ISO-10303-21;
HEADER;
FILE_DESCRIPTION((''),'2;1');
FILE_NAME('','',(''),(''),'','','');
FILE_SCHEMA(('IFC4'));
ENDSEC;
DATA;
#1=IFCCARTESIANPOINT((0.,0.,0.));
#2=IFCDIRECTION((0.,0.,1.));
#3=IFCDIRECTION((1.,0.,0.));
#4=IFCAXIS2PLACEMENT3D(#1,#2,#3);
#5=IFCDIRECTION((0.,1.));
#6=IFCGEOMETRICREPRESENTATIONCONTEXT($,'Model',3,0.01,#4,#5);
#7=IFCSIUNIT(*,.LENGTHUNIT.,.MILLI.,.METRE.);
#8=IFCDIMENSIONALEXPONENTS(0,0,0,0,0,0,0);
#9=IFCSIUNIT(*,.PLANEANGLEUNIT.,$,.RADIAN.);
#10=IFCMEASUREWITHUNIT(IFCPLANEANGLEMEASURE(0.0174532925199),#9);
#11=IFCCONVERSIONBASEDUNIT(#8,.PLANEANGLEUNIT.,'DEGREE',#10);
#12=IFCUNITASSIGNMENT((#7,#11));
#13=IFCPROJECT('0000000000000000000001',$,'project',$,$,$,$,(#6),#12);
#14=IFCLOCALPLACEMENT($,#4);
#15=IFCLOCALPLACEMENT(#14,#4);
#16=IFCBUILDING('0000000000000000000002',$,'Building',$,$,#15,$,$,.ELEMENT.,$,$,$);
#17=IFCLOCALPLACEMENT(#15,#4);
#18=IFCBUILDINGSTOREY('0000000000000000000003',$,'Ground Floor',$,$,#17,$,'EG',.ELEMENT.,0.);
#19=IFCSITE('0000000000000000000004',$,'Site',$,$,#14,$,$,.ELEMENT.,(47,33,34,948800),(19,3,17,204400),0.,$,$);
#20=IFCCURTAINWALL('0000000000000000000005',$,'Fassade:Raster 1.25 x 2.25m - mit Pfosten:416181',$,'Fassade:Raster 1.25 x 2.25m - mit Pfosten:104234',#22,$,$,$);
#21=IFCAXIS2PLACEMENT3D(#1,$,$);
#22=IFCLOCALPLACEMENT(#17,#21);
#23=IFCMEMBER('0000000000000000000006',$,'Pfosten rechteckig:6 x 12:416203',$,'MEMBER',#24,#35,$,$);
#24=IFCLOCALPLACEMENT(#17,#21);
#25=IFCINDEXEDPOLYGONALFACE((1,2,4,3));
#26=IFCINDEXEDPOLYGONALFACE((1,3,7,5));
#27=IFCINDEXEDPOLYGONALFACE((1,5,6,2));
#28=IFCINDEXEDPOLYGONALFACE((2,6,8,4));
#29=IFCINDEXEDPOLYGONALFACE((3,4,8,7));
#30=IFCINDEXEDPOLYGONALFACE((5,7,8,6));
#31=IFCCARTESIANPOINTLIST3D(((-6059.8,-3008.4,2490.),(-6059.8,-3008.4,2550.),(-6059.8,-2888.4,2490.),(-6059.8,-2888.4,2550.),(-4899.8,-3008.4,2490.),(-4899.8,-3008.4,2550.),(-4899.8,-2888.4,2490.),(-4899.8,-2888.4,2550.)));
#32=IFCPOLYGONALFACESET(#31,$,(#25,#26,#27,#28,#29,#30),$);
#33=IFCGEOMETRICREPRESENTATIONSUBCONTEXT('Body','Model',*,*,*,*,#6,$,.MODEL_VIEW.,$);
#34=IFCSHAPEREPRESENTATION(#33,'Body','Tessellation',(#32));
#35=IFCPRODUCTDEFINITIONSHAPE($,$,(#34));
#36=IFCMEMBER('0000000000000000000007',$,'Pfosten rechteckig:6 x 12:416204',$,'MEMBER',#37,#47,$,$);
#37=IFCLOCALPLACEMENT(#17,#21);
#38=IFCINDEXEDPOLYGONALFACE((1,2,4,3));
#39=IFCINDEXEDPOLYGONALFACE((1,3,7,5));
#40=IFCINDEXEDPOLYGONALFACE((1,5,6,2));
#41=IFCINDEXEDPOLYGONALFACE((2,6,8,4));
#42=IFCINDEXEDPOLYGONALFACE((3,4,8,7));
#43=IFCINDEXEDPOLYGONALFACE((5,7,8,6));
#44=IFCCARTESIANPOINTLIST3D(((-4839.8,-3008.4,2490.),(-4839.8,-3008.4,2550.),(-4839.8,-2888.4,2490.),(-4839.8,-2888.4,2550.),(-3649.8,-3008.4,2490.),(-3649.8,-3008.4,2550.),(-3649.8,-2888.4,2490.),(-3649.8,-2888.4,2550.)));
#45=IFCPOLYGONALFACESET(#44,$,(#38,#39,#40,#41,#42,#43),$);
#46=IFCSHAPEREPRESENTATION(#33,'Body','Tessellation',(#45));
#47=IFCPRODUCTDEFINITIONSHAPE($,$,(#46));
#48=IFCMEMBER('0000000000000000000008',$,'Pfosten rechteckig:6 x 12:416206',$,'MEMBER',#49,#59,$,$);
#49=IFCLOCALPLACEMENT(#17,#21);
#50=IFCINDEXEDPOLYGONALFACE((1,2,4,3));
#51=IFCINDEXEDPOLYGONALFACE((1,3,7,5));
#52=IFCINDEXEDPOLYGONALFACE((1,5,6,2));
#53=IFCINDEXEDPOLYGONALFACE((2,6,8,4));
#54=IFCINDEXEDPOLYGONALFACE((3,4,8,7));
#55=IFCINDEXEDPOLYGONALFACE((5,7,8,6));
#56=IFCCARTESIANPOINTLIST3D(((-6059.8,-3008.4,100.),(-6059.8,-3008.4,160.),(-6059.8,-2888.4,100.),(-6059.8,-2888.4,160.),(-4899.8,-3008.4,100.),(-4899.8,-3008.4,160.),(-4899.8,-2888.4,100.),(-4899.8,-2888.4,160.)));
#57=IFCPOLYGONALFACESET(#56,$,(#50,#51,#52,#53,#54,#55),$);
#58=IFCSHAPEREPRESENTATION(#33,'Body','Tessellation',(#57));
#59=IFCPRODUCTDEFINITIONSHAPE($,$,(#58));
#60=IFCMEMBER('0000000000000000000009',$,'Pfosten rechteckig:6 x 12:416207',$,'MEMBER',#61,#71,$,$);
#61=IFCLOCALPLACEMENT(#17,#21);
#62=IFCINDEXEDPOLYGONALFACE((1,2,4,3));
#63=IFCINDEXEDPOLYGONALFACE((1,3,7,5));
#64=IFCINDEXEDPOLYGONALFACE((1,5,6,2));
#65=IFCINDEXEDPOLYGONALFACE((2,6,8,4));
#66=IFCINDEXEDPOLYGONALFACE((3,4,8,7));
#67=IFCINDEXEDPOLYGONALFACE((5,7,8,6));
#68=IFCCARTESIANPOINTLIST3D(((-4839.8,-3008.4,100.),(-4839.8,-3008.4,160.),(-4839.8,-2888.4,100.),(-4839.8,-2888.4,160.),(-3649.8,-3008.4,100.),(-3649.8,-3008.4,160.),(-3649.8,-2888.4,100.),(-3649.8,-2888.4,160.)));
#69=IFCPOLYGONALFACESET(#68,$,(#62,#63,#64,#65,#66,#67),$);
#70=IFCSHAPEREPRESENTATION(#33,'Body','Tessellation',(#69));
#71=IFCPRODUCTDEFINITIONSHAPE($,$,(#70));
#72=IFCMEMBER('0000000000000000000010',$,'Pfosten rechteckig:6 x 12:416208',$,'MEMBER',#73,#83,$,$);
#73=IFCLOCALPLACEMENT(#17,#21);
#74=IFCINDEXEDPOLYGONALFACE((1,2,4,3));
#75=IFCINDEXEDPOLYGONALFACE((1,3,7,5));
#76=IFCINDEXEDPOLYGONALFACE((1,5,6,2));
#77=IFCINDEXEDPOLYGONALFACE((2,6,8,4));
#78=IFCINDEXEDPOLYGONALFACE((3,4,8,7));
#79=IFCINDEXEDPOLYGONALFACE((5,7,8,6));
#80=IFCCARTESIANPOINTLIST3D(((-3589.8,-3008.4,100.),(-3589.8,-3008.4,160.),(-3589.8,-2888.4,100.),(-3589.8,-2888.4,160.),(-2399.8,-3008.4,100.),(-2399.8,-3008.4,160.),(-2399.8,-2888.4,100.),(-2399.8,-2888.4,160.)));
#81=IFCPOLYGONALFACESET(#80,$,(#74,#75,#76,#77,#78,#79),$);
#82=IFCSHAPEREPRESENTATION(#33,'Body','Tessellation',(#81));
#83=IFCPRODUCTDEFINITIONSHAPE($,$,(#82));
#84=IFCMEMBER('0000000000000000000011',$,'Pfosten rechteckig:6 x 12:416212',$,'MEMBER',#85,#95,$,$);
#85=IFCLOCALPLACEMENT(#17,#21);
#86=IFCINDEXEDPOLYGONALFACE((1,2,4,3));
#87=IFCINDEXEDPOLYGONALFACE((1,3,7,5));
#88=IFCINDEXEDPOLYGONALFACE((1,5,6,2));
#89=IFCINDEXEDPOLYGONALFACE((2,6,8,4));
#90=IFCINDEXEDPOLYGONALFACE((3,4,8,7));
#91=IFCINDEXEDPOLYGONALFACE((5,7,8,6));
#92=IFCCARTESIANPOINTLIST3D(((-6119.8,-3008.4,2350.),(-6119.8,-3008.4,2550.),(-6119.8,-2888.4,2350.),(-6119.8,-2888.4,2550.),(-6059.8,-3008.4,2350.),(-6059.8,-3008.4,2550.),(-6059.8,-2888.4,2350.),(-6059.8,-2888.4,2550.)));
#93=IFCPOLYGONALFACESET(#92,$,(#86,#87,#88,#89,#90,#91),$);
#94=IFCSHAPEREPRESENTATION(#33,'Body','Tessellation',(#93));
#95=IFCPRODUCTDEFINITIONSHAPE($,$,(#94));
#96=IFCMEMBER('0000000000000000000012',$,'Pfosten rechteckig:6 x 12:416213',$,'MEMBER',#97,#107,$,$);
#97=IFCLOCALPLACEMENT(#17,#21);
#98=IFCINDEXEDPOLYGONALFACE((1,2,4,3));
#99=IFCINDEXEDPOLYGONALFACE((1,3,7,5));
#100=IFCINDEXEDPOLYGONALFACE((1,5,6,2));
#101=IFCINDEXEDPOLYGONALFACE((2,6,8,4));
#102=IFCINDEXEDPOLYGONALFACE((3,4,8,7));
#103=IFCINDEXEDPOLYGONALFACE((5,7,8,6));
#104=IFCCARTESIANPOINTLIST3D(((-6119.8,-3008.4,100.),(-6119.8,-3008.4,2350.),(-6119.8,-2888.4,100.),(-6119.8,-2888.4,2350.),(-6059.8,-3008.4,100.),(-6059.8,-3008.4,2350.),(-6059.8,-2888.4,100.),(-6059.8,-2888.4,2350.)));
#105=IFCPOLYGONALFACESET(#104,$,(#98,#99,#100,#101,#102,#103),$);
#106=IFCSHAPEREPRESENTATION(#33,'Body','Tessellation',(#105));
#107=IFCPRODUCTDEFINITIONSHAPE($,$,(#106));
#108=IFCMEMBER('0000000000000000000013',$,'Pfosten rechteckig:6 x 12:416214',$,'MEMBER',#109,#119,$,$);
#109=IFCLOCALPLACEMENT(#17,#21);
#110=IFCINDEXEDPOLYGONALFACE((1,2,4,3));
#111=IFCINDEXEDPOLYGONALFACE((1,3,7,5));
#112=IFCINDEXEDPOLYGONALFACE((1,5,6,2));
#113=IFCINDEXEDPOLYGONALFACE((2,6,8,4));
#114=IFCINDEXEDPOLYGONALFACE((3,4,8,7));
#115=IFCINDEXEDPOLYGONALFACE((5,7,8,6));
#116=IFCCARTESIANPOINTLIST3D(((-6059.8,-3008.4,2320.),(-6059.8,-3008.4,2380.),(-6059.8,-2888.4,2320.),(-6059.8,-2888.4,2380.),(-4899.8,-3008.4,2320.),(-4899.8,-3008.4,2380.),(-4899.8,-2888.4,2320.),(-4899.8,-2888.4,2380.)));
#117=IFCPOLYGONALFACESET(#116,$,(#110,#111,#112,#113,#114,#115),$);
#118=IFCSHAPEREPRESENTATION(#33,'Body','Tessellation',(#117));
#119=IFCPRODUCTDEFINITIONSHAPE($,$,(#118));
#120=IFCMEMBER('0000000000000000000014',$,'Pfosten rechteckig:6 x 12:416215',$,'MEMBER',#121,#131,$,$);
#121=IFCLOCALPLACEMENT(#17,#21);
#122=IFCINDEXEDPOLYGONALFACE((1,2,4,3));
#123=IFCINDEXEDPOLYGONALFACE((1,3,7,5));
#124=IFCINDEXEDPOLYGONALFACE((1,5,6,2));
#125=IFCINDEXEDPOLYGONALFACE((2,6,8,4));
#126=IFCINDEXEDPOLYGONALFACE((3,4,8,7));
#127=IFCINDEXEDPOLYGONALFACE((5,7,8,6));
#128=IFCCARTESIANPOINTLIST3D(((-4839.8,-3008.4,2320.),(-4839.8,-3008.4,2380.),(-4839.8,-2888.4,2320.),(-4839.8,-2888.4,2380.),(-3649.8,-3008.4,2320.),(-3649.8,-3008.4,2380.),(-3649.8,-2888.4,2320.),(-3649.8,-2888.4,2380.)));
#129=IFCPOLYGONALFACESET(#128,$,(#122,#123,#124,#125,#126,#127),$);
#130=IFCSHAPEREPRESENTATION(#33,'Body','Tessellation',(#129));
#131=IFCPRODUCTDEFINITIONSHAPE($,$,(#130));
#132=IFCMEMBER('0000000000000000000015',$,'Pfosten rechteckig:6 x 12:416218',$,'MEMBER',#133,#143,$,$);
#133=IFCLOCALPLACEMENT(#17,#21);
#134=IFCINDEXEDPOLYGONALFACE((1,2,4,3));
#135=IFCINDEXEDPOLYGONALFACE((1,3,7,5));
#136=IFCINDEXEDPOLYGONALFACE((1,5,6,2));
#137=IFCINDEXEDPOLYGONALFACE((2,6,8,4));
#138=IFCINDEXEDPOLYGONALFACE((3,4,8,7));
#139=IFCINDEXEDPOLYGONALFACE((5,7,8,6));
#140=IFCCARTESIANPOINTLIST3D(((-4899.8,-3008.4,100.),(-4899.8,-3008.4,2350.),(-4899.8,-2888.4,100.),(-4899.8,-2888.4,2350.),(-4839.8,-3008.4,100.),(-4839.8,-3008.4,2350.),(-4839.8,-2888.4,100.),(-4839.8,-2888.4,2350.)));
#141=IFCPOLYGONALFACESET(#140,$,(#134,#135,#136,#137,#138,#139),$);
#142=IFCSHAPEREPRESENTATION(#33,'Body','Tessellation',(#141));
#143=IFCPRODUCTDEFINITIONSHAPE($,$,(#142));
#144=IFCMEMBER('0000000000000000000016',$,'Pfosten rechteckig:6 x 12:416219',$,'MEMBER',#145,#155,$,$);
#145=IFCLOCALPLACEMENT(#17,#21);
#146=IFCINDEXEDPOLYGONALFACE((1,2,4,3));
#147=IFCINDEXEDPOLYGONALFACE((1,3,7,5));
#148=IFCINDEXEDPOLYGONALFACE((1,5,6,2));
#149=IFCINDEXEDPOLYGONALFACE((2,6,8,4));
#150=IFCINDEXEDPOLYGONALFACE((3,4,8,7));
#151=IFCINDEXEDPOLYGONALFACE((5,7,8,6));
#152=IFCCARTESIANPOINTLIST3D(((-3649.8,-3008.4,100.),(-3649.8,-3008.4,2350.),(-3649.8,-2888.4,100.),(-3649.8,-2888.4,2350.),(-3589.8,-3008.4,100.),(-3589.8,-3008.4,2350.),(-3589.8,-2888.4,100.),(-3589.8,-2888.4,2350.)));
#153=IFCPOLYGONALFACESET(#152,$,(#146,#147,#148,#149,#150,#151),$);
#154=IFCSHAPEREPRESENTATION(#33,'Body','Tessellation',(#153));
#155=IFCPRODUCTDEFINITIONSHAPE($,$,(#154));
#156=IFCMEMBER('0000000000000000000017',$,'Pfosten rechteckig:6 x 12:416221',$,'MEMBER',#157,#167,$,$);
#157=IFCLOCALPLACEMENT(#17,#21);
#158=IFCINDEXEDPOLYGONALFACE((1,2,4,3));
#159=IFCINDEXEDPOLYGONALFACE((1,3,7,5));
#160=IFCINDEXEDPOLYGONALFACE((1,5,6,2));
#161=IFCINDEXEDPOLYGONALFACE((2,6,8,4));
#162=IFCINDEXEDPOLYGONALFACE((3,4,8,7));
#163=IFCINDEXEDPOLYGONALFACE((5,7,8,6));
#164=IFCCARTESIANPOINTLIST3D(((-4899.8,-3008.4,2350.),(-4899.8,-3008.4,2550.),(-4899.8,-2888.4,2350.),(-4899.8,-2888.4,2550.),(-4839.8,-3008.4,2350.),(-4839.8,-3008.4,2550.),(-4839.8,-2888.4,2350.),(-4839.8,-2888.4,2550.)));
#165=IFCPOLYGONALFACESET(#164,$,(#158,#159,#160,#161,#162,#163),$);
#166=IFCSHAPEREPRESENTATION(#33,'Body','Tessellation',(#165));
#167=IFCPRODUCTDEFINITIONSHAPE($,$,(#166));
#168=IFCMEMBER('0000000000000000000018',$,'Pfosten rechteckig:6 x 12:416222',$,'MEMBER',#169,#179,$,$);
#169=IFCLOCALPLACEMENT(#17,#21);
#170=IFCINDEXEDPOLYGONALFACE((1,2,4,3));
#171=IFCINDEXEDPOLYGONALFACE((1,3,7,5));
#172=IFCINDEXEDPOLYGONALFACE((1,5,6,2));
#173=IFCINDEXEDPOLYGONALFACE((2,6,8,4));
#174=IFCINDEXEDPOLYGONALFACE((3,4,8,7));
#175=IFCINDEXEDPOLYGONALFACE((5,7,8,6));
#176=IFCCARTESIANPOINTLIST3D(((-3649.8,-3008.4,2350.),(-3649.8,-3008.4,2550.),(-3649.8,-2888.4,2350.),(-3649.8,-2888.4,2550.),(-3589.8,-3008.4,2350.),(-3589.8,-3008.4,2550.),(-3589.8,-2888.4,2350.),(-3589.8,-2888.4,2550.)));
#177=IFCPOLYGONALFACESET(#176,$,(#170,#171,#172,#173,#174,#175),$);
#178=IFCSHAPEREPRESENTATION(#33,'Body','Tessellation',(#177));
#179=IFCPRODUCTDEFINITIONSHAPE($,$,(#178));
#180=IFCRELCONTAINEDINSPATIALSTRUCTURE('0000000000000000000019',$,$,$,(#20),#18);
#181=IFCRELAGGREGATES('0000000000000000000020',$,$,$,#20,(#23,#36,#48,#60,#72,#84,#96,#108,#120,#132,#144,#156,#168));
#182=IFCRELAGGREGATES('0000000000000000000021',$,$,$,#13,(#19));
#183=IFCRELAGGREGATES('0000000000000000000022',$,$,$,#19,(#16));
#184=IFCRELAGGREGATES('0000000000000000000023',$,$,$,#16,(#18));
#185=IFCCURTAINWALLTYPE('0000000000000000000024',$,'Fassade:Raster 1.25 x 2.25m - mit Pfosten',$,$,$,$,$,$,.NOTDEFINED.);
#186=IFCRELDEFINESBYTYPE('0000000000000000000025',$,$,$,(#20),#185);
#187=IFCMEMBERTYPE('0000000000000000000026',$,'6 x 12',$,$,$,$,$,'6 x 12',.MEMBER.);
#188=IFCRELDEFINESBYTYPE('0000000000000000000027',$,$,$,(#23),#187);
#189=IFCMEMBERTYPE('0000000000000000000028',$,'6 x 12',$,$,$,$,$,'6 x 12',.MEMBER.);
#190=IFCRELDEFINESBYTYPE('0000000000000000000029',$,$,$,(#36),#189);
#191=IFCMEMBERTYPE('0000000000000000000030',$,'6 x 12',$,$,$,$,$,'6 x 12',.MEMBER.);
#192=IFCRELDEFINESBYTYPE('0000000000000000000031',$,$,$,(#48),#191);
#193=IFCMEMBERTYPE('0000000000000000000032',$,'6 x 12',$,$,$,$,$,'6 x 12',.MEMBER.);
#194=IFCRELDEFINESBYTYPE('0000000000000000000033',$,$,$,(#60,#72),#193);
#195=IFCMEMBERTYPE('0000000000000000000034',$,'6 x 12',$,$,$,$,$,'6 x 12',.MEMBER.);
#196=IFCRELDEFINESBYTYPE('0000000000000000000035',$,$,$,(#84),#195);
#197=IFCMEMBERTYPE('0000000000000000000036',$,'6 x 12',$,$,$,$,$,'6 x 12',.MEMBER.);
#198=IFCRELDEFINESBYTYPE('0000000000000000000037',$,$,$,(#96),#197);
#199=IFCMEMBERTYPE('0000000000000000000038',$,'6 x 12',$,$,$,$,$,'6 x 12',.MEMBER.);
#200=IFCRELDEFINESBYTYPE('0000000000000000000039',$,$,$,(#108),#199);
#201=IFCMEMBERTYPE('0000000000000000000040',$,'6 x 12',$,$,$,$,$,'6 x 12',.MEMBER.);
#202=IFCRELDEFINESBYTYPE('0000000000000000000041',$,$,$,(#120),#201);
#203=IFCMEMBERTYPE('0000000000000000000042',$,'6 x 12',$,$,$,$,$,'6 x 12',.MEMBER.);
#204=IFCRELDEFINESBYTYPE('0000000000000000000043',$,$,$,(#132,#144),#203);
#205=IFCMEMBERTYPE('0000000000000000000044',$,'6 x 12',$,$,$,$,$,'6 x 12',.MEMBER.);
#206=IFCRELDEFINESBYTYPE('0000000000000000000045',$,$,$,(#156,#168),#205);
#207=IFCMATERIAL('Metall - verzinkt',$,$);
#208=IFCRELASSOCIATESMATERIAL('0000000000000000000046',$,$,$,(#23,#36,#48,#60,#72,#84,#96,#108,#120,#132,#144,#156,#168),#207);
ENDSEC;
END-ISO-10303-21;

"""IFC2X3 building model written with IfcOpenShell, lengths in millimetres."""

from ifc_helpers import new_model, entity, si_unit, converted_unit, direction, frame, origin_with_axes, origin_2d_with_axis, place, context, subcontext, project, spatial, rectangle, extrude, material, type_object, element, aggregate, save


model = new_model("IFC2X3")

# Units and contexts
model_context = context("Model", 3, precision=0.01, world=origin_with_axes(), true_north=direction((0.0, 1.0)))
body_context = subcontext(model_context, "Body", "Model", "MODEL_VIEW")
ifc_project = project(units=[si_unit("LENGTHUNIT", "METRE", prefix="MILLI"), converted_unit("PLANEANGLEUNIT", "DEGREE", entity("IfcPlaneAngleMeasure", 0.0174532925199), si_unit("PLANEANGLEUNIT", "RADIAN"), dimensions=[0, 0, 0, 0, 0, 0, 0])], contexts=[model_context])

# Site, building, storey
site_placement = place(None, origin_with_axes())
site = spatial("IfcSite", under=ifc_project, at=site_placement, Name="Site", CompositionType="ELEMENT", RefLatitude=(47, 33, 34, 948800), RefLongitude=(19, 3, 17, 204400), RefElevation=0.0)
building_placement = place(site_placement, origin_with_axes())
building = spatial("IfcBuilding", under=site, at=building_placement, Name="Building", CompositionType="ELEMENT")
storey_placement = place(building_placement, origin_with_axes())
storey = spatial("IfcBuildingStorey", under=building, at=storey_placement, Name="Ground Floor", LongName="EG", CompositionType="ELEMENT", Elevation=0.0)

# Curtain wall, members
curtain_wall_type = type_object("IfcCurtainWallType", Name="Fassade:Raster 1.25 x 2.25m - mit Pfosten", PredefinedType="NOTDEFINED")
curtain_wall_placement = place(storey_placement, origin_with_axes())
curtain_wall = element("IfcCurtainWall", 1, at=curtain_wall_placement, inside=storey, type_object=curtain_wall_type, Name="Fassade:Raster 1.25 x 2.25m - mit Pfosten:416181", ObjectType="Fassade:Raster 1.25 x 2.25m - mit Pfosten:104234")
ifc_material_1 = material(Name="Metall - verzinkt")
member_type_1 = type_object("IfcMemberType", Name="6 x 12", ElementType="6 x 12", PredefinedType="MEMBER")
member_1_placement = place(curtain_wall_placement, frame((-4899.8, -2948.4, 2550.0), z_axis=(0.0, 0.0, 1.0), x_axis=(0.0, -1.0, 0.0)))
member_1 = element("IfcMember", 2, at=member_1_placement, type_object=member_type_1, material=ifc_material_1, Name="Pfosten rechteckig:6 x 12:416203", ObjectType="MEMBER", context=body_context, shape_type="SweptSolid", body=[
    extrude(rectangle(XDim=120.0, YDim=60.0, at=origin_2d_with_axis()), frame((0.0, -1160.0, -30.0), z_axis=(0.0, 1.0, 0.0), x_axis=(-1.0, 0.0, 0.0)), (0.0, 0.0, 1.0), 1160.0),
])
member_type_2 = type_object("IfcMemberType", Name="6 x 12", ElementType="6 x 12", PredefinedType="MEMBER")
member_2_placement = place(curtain_wall_placement, frame((-3649.8, -2948.4, 2550.0), z_axis=(0.0, 0.0, 1.0), x_axis=(0.0, -1.0, 0.0)))
member_2 = element("IfcMember", 3, at=member_2_placement, type_object=member_type_2, material=ifc_material_1, Name="Pfosten rechteckig:6 x 12:416204", ObjectType="MEMBER", context=body_context, shape_type="SweptSolid", body=[
    extrude(rectangle(XDim=120.0, YDim=60.0, at=origin_2d_with_axis()), frame((0.0, -1190.0, -30.0), z_axis=(0.0, 1.0, 0.0), x_axis=(-1.0, 0.0, 0.0)), (0.0, 0.0, 1.0), 1190.0),
])
member_type_3 = type_object("IfcMemberType", Name="6 x 12", ElementType="6 x 12", PredefinedType="MEMBER")
member_3_placement = place(curtain_wall_placement, frame((-6059.8, -2948.4, 100.0), z_axis=(0.0, 0.0, 1.0), x_axis=(0.0, -1.0, 0.0)))
member_3 = element("IfcMember", 4, at=member_3_placement, type_object=member_type_3, material=ifc_material_1, Name="Pfosten rechteckig:6 x 12:416206", ObjectType="MEMBER", context=body_context, shape_type="SweptSolid", body=[
    extrude(rectangle(XDim=120.0, YDim=60.0, at=origin_2d_with_axis()), frame((0.0, 1160.0, 30.0), z_axis=(0.0, -1.0, 0.0), x_axis=(-1.0, 0.0, 0.0)), (0.0, 0.0, 1.0), 1160.0),
])
member_type_4 = type_object("IfcMemberType", Name="6 x 12", ElementType="6 x 12", PredefinedType="MEMBER")
member_4_placement = place(curtain_wall_placement, frame((-4839.8, -2948.4, 100.0), z_axis=(0.0, 0.0, 1.0), x_axis=(0.0, -1.0, 0.0)))
member_4 = element("IfcMember", 5, at=member_4_placement, type_object=member_type_4, material=ifc_material_1, Name="Pfosten rechteckig:6 x 12:416207", ObjectType="MEMBER", context=body_context, shape_type="SweptSolid", body=[
    extrude(rectangle(XDim=120.0, YDim=60.0, at=origin_2d_with_axis()), frame((0.0, 1190.0, 30.0), z_axis=(0.0, -1.0, 0.0), x_axis=(-1.0, 0.0, 0.0)), (0.0, 0.0, 1.0), 1190.0),
])
member_5_placement = place(curtain_wall_placement, frame((-3589.8, -2948.4, 100.0), z_axis=(0.0, 0.0, 1.0), x_axis=(0.0, -1.0, 0.0)))
member_5 = element("IfcMember", 6, at=member_5_placement, type_object=member_type_4, material=ifc_material_1, Name="Pfosten rechteckig:6 x 12:416208", ObjectType="MEMBER", context=body_context, shape_type="SweptSolid", body=[
    extrude(rectangle(XDim=120.0, YDim=60.0, at=origin_2d_with_axis()), frame((0.0, 1190.0, 30.0), z_axis=(0.0, -1.0, 0.0), x_axis=(-1.0, 0.0, 0.0)), (0.0, 0.0, 1.0), 1190.0),
])
member_type_5 = type_object("IfcMemberType", Name="6 x 12", ElementType="6 x 12", PredefinedType="MEMBER")
member_6_placement = place(curtain_wall_placement, frame((-6119.8, -2948.4, 2550.0), z_axis=(0.0, 0.0, 1.0), x_axis=(-1.0, 0.0, 0.0)))
member_6 = element("IfcMember", 7, at=member_6_placement, type_object=member_type_5, material=ifc_material_1, Name="Pfosten rechteckig:6 x 12:416212", ObjectType="MEMBER", context=body_context, shape_type="SweptSolid", body=[
    extrude(rectangle(XDim=120.0, YDim=60.0, at=origin_2d_with_axis()), frame((-30.0, 0.0, -200.0), z_axis=(0.0, 0.0, 1.0), x_axis=(0.0, -1.0, 0.0)), (0.0, 0.0, 1.0), 200.0),
])
member_type_6 = type_object("IfcMemberType", Name="6 x 12", ElementType="6 x 12", PredefinedType="MEMBER")
member_7_placement = place(curtain_wall_placement, frame((-6119.8, -2948.4, 2350.0), z_axis=(0.0, 0.0, 1.0), x_axis=(-1.0, 0.0, 0.0)))
member_7 = element("IfcMember", 8, at=member_7_placement, type_object=member_type_6, material=ifc_material_1, Name="Pfosten rechteckig:6 x 12:416213", ObjectType="MEMBER", context=body_context, shape_type="SweptSolid", body=[
    extrude(rectangle(XDim=120.0, YDim=60.0, at=origin_2d_with_axis()), frame((-30.0, 0.0, -2250.0), z_axis=(0.0, 0.0, 1.0), x_axis=(0.0, -1.0, 0.0)), (0.0, 0.0, 1.0), 2250.0),
])
member_type_7 = type_object("IfcMemberType", Name="6 x 12", ElementType="6 x 12", PredefinedType="MEMBER")
member_8_placement = place(curtain_wall_placement, frame((-4899.8, -2948.4, 2350.0), z_axis=(0.0, 0.0, 1.0), x_axis=(0.0, -1.0, 0.0)))
member_8 = element("IfcMember", 9, at=member_8_placement, type_object=member_type_7, material=ifc_material_1, Name="Pfosten rechteckig:6 x 12:416214", ObjectType="MEMBER", context=body_context, shape_type="SweptSolid", body=[
    extrude(rectangle(XDim=120.0, YDim=60.0, at=origin_2d_with_axis()), frame((0.0, -1160.0, 0.0), z_axis=(0.0, 1.0, 0.0), x_axis=(-1.0, 0.0, 0.0)), (0.0, 0.0, 1.0), 1160.0),
])
member_type_8 = type_object("IfcMemberType", Name="6 x 12", ElementType="6 x 12", PredefinedType="MEMBER")
member_9_placement = place(curtain_wall_placement, frame((-3649.8, -2948.4, 2350.0), z_axis=(0.0, 0.0, 1.0), x_axis=(0.0, -1.0, 0.0)))
member_9 = element("IfcMember", 10, at=member_9_placement, type_object=member_type_8, material=ifc_material_1, Name="Pfosten rechteckig:6 x 12:416215", ObjectType="MEMBER", context=body_context, shape_type="SweptSolid", body=[
    extrude(rectangle(XDim=120.0, YDim=60.0, at=origin_2d_with_axis()), frame((0.0, -1190.0, 0.0), z_axis=(0.0, 1.0, 0.0), x_axis=(-1.0, 0.0, 0.0)), (0.0, 0.0, 1.0), 1190.0),
])
member_type_9 = type_object("IfcMemberType", Name="6 x 12", ElementType="6 x 12", PredefinedType="MEMBER")
member_10_placement = place(curtain_wall_placement, frame((-4869.8, -2948.4, 100.0), z_axis=(0.0, 0.0, 1.0), x_axis=(1.0, 0.0, 0.0)))
member_10 = element("IfcMember", 11, at=member_10_placement, type_object=member_type_9, material=ifc_material_1, Name="Pfosten rechteckig:6 x 12:416218", ObjectType="MEMBER", context=body_context, shape_type="SweptSolid", body=[
    extrude(rectangle(XDim=120.0, YDim=60.0, at=origin_2d_with_axis()), frame((0.0, 0.0, 2250.0), z_axis=(0.0, 0.0, -1.0), x_axis=(0.0, 1.0, 0.0)), (0.0, 0.0, 1.0), 2250.0),
])
member_11_placement = place(curtain_wall_placement, frame((-3619.8, -2948.4, 100.0), z_axis=(0.0, 0.0, 1.0), x_axis=(1.0, 0.0, 0.0)))
member_11 = element("IfcMember", 12, at=member_11_placement, type_object=member_type_9, material=ifc_material_1, Name="Pfosten rechteckig:6 x 12:416219", ObjectType="MEMBER", context=body_context, shape_type="SweptSolid", body=[
    extrude(rectangle(XDim=120.0, YDim=60.0, at=origin_2d_with_axis()), frame((0.0, 0.0, 2250.0), z_axis=(0.0, 0.0, -1.0), x_axis=(0.0, 1.0, 0.0)), (0.0, 0.0, 1.0), 2250.0),
])
member_type_10 = type_object("IfcMemberType", Name="6 x 12", ElementType="6 x 12", PredefinedType="MEMBER")
member_12_placement = place(curtain_wall_placement, frame((-4869.8, -2948.4, 2350.0), z_axis=(0.0, 0.0, 1.0), x_axis=(1.0, 0.0, 0.0)))
member_12 = element("IfcMember", 13, at=member_12_placement, type_object=member_type_10, material=ifc_material_1, Name="Pfosten rechteckig:6 x 12:416221", ObjectType="MEMBER", context=body_context, shape_type="SweptSolid", body=[
    extrude(rectangle(XDim=120.0, YDim=60.0, at=origin_2d_with_axis()), frame((0.0, 0.0, 200.0), z_axis=(0.0, 0.0, -1.0), x_axis=(0.0, 1.0, 0.0)), (0.0, 0.0, 1.0), 200.0),
])
member_13_placement = place(curtain_wall_placement, frame((-3619.8, -2948.4, 2350.0), z_axis=(0.0, 0.0, 1.0), x_axis=(1.0, 0.0, 0.0)))
member_13 = element("IfcMember", 14, at=member_13_placement, type_object=member_type_10, material=ifc_material_1, Name="Pfosten rechteckig:6 x 12:416222", ObjectType="MEMBER", context=body_context, shape_type="SweptSolid", body=[
    extrude(rectangle(XDim=120.0, YDim=60.0, at=origin_2d_with_axis()), frame((0.0, 0.0, 200.0), z_axis=(0.0, 0.0, -1.0), x_axis=(0.0, 1.0, 0.0)), (0.0, 0.0, 1.0), 200.0),
])

aggregate(curtain_wall, [member_1, member_2, member_3, member_4, member_5, member_6, member_7, member_8, member_9, member_10, member_11, member_12, member_13])

save(model, "model.ifc")
